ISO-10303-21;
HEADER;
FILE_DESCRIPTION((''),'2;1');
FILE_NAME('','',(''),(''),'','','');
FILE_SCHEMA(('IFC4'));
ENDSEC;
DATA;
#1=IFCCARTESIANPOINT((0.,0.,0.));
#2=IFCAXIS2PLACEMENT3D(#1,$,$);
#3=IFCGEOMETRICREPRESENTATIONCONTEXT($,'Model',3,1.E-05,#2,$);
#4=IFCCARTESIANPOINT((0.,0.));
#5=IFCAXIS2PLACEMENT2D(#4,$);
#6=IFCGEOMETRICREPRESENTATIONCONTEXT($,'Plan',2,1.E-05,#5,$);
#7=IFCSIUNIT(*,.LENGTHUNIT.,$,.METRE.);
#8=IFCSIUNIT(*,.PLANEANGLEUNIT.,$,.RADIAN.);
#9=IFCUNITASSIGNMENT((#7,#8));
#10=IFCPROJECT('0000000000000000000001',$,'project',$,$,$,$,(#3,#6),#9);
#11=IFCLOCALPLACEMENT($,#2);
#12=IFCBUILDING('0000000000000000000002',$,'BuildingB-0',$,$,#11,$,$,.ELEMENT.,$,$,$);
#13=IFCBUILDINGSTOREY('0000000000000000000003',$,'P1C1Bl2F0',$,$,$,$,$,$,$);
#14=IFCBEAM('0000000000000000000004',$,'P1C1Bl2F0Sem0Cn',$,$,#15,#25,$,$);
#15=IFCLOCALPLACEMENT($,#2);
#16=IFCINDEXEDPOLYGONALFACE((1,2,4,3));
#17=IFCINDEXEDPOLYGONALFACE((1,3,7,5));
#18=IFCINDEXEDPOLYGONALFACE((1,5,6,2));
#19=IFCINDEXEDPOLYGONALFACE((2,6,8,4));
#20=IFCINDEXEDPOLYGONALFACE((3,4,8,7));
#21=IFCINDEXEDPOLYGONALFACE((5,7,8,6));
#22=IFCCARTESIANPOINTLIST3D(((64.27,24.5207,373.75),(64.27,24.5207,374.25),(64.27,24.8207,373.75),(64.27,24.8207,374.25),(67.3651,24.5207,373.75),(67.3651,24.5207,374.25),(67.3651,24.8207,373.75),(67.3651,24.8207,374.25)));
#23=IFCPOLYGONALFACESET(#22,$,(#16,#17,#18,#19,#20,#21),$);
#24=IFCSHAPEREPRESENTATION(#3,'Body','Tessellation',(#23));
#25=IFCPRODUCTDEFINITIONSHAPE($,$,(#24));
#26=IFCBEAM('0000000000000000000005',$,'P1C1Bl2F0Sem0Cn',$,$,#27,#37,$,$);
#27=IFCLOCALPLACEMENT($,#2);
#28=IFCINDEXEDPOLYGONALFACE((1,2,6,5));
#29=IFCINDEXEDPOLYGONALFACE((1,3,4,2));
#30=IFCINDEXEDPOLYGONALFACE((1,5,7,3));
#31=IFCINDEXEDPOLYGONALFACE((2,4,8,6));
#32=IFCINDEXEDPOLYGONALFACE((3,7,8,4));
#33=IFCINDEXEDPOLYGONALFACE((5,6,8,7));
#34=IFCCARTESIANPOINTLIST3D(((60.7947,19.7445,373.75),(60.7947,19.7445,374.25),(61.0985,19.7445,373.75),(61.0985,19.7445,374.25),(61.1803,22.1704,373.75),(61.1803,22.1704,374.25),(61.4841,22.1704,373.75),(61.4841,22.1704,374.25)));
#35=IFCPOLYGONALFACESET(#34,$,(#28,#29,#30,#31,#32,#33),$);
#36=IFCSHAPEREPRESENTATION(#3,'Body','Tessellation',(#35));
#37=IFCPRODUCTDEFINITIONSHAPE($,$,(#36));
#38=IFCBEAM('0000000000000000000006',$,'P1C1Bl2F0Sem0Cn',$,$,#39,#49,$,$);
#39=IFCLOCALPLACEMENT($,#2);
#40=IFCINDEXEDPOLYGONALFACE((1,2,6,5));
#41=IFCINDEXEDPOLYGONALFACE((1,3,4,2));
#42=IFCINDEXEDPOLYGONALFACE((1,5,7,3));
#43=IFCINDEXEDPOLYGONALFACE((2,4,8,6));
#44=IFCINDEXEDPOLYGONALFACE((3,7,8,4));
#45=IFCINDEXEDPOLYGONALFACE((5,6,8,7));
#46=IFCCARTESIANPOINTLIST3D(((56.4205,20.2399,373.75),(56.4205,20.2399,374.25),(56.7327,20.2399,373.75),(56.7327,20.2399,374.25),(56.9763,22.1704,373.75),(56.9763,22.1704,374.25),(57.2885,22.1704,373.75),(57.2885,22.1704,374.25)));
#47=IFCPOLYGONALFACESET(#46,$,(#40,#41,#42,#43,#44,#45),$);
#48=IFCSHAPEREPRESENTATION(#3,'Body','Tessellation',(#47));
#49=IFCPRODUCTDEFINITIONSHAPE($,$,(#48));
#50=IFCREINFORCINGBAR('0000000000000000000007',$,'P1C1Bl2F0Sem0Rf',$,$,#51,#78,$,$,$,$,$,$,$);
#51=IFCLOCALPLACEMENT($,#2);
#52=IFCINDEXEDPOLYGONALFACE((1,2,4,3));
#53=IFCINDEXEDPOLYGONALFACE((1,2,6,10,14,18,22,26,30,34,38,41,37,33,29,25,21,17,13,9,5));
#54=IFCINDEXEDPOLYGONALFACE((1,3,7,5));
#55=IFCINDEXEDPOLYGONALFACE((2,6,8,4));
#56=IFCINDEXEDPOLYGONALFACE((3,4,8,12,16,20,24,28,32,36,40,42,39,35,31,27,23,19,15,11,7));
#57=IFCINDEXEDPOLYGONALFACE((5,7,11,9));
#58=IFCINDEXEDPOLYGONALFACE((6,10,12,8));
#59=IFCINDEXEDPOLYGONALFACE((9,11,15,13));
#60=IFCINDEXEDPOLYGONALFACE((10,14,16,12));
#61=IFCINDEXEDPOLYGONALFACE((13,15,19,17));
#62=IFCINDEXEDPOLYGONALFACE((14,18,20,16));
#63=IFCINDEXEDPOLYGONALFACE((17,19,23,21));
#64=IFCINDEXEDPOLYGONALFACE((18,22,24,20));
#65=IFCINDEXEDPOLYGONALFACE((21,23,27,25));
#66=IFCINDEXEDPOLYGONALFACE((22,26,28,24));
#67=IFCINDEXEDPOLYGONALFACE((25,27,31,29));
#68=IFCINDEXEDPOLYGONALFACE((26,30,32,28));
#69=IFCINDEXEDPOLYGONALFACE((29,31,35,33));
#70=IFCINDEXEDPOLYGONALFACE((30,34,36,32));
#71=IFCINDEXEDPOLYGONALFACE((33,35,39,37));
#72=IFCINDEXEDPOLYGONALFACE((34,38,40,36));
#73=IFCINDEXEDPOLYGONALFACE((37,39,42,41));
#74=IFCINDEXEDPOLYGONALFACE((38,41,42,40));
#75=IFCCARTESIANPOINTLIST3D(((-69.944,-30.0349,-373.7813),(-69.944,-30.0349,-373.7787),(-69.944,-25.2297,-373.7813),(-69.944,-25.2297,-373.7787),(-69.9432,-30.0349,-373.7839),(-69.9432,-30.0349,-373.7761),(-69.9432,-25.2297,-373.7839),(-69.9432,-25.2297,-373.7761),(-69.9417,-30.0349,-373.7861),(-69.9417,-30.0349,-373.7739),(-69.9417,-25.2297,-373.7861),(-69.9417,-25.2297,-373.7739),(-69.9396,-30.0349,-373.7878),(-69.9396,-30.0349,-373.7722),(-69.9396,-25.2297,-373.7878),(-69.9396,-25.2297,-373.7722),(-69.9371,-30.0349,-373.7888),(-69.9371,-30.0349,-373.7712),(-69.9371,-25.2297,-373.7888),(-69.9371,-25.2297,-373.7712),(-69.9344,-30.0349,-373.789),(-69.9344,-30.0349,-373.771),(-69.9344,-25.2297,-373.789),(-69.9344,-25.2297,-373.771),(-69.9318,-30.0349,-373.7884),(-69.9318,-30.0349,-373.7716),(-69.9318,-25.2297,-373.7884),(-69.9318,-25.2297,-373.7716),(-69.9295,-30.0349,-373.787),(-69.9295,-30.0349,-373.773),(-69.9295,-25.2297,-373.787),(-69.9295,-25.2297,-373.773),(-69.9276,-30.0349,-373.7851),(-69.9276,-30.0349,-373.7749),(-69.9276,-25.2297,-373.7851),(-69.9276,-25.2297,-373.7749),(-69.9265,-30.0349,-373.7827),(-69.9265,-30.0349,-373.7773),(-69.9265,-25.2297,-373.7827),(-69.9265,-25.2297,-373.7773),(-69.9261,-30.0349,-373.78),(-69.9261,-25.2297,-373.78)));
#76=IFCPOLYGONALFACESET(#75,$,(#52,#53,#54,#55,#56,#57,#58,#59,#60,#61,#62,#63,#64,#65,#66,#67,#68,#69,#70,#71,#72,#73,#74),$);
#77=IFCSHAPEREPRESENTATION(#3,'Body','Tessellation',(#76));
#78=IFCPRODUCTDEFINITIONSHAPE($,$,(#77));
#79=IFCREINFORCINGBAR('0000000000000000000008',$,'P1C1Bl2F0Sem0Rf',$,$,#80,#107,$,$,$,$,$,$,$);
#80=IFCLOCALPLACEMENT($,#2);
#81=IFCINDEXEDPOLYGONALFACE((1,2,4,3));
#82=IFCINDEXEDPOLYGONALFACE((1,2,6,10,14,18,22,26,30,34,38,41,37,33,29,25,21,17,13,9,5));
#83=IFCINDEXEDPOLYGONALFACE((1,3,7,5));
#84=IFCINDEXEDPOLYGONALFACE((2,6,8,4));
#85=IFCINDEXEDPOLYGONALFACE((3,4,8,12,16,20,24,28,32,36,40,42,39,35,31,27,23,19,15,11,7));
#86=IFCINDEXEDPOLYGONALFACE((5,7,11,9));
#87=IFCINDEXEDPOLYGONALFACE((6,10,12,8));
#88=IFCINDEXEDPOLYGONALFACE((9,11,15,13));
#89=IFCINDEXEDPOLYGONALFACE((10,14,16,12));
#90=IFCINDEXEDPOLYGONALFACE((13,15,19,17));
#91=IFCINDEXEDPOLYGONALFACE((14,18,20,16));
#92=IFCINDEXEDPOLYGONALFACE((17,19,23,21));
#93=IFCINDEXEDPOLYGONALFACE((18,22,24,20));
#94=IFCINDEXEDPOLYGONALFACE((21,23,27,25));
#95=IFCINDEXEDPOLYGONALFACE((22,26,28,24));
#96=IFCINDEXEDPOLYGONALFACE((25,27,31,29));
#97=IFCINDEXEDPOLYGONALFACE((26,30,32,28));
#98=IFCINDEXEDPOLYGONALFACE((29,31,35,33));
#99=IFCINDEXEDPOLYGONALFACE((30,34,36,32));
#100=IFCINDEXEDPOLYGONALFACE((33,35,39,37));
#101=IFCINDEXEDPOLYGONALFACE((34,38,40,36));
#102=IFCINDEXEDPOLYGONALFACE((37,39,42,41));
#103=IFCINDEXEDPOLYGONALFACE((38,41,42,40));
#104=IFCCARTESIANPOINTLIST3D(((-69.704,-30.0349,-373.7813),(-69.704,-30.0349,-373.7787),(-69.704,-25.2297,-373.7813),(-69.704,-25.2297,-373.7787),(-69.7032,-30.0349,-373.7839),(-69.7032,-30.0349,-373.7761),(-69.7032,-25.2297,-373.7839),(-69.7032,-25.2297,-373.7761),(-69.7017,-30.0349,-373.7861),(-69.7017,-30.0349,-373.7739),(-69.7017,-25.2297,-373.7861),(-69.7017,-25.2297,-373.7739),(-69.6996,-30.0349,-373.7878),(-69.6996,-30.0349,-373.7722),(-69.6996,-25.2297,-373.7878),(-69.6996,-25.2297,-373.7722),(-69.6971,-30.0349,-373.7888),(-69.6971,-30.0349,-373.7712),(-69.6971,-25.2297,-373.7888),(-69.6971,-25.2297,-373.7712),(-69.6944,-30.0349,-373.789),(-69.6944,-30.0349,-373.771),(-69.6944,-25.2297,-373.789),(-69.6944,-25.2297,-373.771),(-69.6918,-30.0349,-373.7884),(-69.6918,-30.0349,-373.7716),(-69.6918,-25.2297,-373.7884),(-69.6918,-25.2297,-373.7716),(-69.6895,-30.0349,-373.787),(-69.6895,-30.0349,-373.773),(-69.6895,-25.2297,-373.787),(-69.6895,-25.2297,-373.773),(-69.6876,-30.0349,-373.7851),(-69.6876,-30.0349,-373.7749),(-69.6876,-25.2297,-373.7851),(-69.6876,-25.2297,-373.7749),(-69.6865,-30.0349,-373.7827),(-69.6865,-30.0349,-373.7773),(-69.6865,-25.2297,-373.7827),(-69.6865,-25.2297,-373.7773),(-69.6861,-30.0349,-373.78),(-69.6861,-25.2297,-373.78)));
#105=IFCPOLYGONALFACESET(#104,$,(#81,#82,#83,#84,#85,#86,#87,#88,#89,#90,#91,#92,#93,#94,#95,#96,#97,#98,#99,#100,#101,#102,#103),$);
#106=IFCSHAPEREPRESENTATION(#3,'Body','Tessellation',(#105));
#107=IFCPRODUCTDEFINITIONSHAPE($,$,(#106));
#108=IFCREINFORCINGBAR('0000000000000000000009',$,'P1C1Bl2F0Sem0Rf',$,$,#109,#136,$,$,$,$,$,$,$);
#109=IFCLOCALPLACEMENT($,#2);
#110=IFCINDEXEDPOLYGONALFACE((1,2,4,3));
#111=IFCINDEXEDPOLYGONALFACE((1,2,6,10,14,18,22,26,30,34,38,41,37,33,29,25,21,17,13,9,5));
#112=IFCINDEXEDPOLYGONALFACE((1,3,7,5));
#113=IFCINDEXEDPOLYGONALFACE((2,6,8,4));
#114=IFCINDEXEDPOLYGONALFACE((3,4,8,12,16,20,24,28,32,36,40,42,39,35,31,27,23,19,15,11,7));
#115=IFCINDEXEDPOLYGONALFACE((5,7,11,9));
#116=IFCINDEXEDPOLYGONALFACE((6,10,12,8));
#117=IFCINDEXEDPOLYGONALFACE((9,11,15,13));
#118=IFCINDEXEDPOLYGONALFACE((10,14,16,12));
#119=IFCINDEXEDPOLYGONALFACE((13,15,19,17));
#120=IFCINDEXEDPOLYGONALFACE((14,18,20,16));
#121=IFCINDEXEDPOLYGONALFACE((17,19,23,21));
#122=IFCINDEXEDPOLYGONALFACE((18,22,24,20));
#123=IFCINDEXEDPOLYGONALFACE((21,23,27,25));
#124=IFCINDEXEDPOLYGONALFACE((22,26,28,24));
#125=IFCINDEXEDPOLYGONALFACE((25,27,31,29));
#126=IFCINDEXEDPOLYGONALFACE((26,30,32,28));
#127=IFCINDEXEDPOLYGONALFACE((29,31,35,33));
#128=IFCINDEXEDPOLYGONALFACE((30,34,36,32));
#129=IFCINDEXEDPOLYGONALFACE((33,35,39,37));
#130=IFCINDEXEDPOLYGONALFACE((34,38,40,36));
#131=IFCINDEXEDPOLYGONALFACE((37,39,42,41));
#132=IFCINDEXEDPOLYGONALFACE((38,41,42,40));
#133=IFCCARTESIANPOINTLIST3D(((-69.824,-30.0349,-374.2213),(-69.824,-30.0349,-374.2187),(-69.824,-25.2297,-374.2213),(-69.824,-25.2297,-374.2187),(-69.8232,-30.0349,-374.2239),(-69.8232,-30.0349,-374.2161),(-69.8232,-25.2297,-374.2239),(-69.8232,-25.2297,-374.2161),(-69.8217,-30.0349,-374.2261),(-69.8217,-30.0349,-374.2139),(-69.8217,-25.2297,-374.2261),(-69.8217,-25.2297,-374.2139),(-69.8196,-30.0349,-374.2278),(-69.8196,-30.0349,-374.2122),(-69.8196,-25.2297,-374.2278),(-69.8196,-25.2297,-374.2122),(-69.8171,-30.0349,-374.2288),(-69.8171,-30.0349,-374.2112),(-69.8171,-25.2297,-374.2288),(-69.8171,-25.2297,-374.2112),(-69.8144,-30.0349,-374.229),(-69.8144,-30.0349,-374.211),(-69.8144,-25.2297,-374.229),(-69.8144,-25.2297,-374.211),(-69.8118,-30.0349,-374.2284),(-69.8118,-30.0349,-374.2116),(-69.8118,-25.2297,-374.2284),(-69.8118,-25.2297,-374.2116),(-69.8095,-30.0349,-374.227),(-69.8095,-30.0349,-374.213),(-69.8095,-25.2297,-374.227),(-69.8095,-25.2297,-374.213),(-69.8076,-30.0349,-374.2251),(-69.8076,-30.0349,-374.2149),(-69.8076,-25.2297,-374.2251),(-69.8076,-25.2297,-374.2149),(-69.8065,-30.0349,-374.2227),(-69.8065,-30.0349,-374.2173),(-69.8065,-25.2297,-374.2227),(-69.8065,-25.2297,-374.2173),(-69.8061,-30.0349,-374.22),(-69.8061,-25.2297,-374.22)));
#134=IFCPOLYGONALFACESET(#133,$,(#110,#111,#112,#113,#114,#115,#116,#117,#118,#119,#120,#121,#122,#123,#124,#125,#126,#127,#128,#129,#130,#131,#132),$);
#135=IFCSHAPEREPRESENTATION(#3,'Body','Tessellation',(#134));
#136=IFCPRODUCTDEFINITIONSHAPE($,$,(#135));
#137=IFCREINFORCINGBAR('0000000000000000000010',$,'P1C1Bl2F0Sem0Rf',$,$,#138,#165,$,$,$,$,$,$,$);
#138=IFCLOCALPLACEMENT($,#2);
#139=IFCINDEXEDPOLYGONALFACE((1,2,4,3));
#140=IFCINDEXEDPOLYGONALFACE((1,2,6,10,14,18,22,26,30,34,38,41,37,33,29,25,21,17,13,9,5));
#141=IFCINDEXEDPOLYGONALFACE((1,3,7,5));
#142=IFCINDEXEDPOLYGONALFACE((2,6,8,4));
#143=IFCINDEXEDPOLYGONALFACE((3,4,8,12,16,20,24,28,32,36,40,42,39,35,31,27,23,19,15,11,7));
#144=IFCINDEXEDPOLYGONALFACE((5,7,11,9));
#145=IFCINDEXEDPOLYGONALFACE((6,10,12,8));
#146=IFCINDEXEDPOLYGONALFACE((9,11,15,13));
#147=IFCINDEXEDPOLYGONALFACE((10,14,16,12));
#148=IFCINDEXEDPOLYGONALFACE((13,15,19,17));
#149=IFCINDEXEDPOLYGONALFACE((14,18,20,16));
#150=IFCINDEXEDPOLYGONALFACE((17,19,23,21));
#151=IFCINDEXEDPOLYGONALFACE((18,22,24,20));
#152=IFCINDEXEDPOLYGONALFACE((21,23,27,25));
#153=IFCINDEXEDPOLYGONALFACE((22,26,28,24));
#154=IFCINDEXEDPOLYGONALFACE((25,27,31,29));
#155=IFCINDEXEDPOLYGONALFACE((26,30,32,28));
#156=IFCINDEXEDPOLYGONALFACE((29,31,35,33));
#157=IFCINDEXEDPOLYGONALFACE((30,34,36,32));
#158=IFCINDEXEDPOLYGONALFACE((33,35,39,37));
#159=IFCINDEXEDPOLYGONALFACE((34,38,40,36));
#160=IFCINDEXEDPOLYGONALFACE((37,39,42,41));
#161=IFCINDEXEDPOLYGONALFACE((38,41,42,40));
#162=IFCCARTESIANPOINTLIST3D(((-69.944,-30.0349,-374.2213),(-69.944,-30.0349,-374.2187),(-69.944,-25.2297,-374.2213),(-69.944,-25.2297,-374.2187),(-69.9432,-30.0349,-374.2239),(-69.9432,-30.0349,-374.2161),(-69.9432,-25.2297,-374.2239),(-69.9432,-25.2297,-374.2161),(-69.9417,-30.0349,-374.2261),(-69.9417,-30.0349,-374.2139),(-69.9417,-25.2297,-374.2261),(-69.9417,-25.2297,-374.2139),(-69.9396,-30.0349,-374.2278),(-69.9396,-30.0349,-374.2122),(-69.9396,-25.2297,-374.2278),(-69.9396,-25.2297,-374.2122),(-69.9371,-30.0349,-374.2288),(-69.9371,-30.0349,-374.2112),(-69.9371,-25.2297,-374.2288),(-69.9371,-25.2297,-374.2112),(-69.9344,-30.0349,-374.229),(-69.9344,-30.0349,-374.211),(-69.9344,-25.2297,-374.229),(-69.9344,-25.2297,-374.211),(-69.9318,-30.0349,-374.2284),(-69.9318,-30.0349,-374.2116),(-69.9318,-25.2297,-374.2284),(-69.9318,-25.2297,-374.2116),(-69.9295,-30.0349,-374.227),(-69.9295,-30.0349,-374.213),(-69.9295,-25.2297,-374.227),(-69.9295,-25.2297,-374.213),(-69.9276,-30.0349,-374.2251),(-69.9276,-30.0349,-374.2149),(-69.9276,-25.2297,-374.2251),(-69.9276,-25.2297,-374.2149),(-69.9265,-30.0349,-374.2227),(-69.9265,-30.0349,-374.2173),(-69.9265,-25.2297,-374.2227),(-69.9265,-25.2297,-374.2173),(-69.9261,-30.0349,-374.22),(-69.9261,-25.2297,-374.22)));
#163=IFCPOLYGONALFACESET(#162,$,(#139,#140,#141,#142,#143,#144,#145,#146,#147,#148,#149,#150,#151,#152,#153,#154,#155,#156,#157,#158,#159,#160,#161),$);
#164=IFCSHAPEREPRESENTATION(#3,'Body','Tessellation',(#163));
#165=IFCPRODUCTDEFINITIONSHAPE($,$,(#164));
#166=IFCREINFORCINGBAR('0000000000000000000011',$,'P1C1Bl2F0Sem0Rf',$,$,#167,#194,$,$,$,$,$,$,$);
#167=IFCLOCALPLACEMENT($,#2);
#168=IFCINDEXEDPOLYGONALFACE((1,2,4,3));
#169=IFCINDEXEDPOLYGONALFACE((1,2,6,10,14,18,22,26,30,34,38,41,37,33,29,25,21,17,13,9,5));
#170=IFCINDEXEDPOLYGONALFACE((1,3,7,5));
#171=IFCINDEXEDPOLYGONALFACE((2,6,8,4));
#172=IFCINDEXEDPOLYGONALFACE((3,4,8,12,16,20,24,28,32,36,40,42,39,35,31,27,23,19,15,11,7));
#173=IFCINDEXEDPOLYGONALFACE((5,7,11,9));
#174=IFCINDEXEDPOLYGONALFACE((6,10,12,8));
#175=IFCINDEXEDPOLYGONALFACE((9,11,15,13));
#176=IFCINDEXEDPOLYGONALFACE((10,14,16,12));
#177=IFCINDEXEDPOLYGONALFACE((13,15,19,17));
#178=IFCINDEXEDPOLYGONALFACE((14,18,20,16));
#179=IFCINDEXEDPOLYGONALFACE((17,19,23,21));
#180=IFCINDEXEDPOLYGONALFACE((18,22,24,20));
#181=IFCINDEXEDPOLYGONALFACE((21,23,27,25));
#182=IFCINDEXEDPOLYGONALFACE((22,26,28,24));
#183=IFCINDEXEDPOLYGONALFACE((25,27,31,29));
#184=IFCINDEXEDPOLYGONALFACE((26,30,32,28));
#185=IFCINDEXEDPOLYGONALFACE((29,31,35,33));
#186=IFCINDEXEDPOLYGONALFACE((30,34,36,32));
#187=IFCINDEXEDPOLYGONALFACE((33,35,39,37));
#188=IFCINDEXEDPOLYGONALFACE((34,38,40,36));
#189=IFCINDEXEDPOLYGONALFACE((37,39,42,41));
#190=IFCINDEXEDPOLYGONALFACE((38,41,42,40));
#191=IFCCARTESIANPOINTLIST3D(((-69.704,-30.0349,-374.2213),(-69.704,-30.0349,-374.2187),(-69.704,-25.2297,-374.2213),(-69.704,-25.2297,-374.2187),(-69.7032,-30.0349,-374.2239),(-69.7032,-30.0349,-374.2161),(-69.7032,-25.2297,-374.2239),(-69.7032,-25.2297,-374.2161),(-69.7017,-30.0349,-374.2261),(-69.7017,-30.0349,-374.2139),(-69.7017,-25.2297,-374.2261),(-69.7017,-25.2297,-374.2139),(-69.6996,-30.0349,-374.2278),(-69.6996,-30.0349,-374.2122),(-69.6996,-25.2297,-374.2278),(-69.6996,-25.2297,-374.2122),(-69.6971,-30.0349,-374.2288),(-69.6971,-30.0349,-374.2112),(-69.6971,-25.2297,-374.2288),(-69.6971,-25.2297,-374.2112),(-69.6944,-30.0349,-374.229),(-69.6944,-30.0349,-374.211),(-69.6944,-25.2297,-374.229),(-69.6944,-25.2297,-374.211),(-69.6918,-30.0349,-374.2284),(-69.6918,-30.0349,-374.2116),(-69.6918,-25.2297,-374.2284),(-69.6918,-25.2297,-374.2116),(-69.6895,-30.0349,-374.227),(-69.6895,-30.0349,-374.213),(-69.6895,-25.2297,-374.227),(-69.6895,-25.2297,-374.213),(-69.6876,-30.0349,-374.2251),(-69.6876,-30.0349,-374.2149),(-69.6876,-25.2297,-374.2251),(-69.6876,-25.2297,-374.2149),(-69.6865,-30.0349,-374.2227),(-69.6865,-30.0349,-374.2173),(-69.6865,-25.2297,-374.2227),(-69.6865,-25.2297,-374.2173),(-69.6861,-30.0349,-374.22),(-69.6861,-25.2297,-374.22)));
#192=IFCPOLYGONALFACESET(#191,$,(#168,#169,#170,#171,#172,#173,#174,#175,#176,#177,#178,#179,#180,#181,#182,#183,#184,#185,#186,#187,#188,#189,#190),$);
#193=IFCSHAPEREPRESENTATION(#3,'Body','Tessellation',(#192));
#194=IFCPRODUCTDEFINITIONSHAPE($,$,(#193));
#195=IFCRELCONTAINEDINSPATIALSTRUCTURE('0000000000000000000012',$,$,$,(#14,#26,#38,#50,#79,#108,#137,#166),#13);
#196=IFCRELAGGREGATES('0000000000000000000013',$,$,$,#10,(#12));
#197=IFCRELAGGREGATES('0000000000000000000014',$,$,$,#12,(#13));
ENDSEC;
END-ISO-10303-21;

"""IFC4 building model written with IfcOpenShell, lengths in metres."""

from ifc_helpers import new_model, entity, si_unit, origin, origin_2d, place, context, project, spatial, polyline, outline, extrude, element, save


model = new_model("IFC4")

# Units and contexts
model_context = context("Model", 3, precision=1e-05, world=origin())
plan_context = context("Plan", 2, precision=1e-05, world=origin_2d())
ifc_project = project(units=[si_unit("LENGTHUNIT", "METRE"), si_unit("PLANEANGLEUNIT", "RADIAN")], contexts=[model_context, plan_context])

# Building, storey
building_placement = place(None, origin())
building = spatial("IfcBuilding", under=ifc_project, at=building_placement, Name="BuildingB-0", CompositionType="ELEMENT")
storey = spatial("IfcBuildingStorey", under=building, Name="P1C1Bl2F0")

# Beams
element("IfcBeam", 1, inside=storey, Name="P1C1Bl2F0Sem0Cn", context=model_context, shape_type="SweptSolid", body=[
    extrude(outline(polyline([(67.3651, 24.5207, 373.75), (67.3651, 24.8207, 373.75), (64.27, 24.8207, 373.75), (64.27, 24.5207, 373.75), (67.3651, 24.5207, 373.75)])), None, (0.0, 0.0, 1.0), 0.5),
])
element("IfcBeam", 2, inside=storey, Name="P1C1Bl2F0Sem0Cn", context=model_context, shape_type="SweptSolid", body=[
    extrude(outline(polyline([(61.0985, 19.7445, 373.75), (60.7947, 19.7445, 373.75), (61.1803, 22.1704, 373.75), (61.4841, 22.1704, 373.75), (61.0985, 19.7445, 373.75)])), None, (0.0, 0.0, 1.0), 0.5),
])
element("IfcBeam", 3, inside=storey, Name="P1C1Bl2F0Sem0Cn", context=model_context, shape_type="SweptSolid", body=[
    extrude(outline(polyline([(56.7327, 20.2399, 373.75), (56.4205, 20.2399, 373.75), (56.9763, 22.1704, 373.75), (57.2885, 22.1704, 373.75), (56.7327, 20.2399, 373.75)])), None, (0.0, 0.0, 1.0), 0.5),
])

# Reinforcing bars
element("IfcReinforcingBar", 4, inside=storey, Name="P1C1Bl2F0Sem0Rf", context=model_context, shape_type="SweptSolid", body=[
    entity("IfcSurfaceCurveSweptAreaSolid", entity("IfcCircleProfileDef", "AREA", None, None, 0.009), None, entity("IfcPolyline", [entity("IfcCartesianPoint", [69.9351, 25.2297, 373.78]), entity("IfcCartesianPoint", [69.9351, 30.0349, 373.78])]), None, None, entity("IfcPlane", entity("IfcAxis2Placement3D", entity("IfcCartesianPoint", [69.9351, 25.2297, 373.78]), entity("IfcDirection", [0.0, 0.0, 1.0]), entity("IfcDirection", [1.0, 0.0, 0.0])))),
])
element("IfcReinforcingBar", 5, inside=storey, Name="P1C1Bl2F0Sem0Rf", context=model_context, shape_type="SweptSolid", body=[
    entity("IfcSurfaceCurveSweptAreaSolid", entity("IfcCircleProfileDef", "AREA", None, None, 0.009), None, entity("IfcPolyline", [entity("IfcCartesianPoint", [69.6951, 25.2297, 373.78]), entity("IfcCartesianPoint", [69.6951, 30.0349, 373.78])]), None, None, entity("IfcPlane", entity("IfcAxis2Placement3D", entity("IfcCartesianPoint", [69.6951, 25.2297, 373.78]), entity("IfcDirection", [0.0, 0.0, 1.0]), entity("IfcDirection", [1.0, 0.0, 0.0])))),
])
element("IfcReinforcingBar", 6, inside=storey, Name="P1C1Bl2F0Sem0Rf", context=model_context, shape_type="SweptSolid", body=[
    entity("IfcSurfaceCurveSweptAreaSolid", entity("IfcCircleProfileDef", "AREA", None, None, 0.009), None, entity("IfcPolyline", [entity("IfcCartesianPoint", [69.8151, 25.2297, 374.22]), entity("IfcCartesianPoint", [69.8151, 30.0349, 374.22])]), None, None, entity("IfcPlane", entity("IfcAxis2Placement3D", entity("IfcCartesianPoint", [69.8151, 25.2297, 374.22]), entity("IfcDirection", [0.0, 0.0, 1.0]), entity("IfcDirection", [1.0, 0.0, 0.0])))),
])
element("IfcReinforcingBar", 7, inside=storey, Name="P1C1Bl2F0Sem0Rf", context=model_context, shape_type="SweptSolid", body=[
    entity("IfcSurfaceCurveSweptAreaSolid", entity("IfcCircleProfileDef", "AREA", None, None, 0.009), None, entity("IfcPolyline", [entity("IfcCartesianPoint", [69.9351, 25.2297, 374.22]), entity("IfcCartesianPoint", [69.9351, 30.0349, 374.22])]), None, None, entity("IfcPlane", entity("IfcAxis2Placement3D", entity("IfcCartesianPoint", [69.9351, 25.2297, 374.22]), entity("IfcDirection", [0.0, 0.0, 1.0]), entity("IfcDirection", [1.0, 0.0, 0.0])))),
])
element("IfcReinforcingBar", 8, inside=storey, Name="P1C1Bl2F0Sem0Rf", context=model_context, shape_type="SweptSolid", body=[
    entity("IfcSurfaceCurveSweptAreaSolid", entity("IfcCircleProfileDef", "AREA", None, None, 0.009), None, entity("IfcPolyline", [entity("IfcCartesianPoint", [69.6951, 25.2297, 374.22]), entity("IfcCartesianPoint", [69.6951, 30.0349, 374.22])]), None, None, entity("IfcPlane", entity("IfcAxis2Placement3D", entity("IfcCartesianPoint", [69.6951, 25.2297, 374.22]), entity("IfcDirection", [0.0, 0.0, 1.0]), entity("IfcDirection", [1.0, 0.0, 0.0])))),
])

save(model, "model.ifc")
